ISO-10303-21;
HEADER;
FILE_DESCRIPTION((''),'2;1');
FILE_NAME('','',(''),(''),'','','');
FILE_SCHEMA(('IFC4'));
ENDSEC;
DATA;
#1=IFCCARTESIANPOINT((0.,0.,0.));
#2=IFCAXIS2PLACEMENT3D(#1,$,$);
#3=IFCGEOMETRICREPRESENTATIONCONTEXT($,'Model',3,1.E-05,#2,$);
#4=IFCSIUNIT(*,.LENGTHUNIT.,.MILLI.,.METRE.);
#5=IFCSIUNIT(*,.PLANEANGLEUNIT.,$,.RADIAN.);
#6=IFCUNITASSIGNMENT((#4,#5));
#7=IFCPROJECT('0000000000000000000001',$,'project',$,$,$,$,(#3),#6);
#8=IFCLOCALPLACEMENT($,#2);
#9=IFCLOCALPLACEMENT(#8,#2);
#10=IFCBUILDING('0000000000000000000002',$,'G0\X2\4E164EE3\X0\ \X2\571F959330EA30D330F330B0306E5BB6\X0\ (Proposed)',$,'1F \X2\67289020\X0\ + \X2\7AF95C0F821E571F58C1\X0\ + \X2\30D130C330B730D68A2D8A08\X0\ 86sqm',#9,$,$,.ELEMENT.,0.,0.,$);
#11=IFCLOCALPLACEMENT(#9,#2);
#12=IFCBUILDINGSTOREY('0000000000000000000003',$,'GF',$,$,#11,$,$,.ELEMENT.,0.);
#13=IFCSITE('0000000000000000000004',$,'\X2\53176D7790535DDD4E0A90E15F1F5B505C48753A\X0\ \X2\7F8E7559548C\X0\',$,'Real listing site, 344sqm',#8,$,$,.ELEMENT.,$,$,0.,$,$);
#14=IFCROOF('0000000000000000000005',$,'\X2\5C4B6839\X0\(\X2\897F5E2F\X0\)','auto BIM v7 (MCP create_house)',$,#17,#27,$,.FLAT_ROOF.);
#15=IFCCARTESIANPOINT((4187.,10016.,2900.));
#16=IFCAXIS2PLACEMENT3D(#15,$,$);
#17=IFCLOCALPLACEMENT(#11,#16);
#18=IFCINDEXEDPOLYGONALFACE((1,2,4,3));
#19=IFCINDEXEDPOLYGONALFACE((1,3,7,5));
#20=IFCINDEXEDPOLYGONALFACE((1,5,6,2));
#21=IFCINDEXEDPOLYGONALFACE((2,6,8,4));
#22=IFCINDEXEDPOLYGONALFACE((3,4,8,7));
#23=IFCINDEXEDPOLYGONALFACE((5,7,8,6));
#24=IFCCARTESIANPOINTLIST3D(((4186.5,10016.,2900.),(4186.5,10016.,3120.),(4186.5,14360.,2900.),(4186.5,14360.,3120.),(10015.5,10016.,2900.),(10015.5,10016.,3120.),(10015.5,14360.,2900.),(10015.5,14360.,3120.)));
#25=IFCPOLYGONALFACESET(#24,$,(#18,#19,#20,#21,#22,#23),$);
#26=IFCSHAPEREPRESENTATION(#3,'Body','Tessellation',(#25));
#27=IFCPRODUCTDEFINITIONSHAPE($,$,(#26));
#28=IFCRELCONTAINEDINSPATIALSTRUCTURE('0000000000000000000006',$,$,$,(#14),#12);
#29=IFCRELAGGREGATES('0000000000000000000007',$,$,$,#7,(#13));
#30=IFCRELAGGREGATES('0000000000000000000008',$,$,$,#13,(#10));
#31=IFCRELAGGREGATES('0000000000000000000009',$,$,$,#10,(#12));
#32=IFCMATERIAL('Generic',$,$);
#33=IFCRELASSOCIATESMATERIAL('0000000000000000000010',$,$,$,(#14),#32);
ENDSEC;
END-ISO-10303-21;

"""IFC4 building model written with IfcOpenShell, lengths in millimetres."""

from ifc_helpers import new_model, si_unit, frame, frame_2d, origin, place, context, project, spatial, rectangle, extrude, material, element, save


model = new_model("IFC4")

# Units and contexts
model_context = context("Model", 3, precision=1e-05, world=origin())
ifc_project = project(units=[si_unit("LENGTHUNIT", "METRE", prefix="MILLI"), si_unit("PLANEANGLEUNIT", "RADIAN")], contexts=[model_context])

# Site, building, storey
site_placement = place(None, origin())
site = spatial("IfcSite", under=ifc_project, at=site_placement, Name="北海道川上郡弟子屈町 美留和", ObjectType="Real listing site, 344sqm", CompositionType="ELEMENT", RefElevation=0.0)
building_placement = place(site_placement, origin())
building = spatial("IfcBuilding", under=site, at=building_placement, Name="G0世代 土間リビングの家 (Proposed)", ObjectType="1F 木造 + 竹小舞土壁 + パッシブ設計 86sqm", CompositionType="ELEMENT", ElevationOfRefHeight=0.0, ElevationOfTerrain=0.0)
storey_placement = place(building_placement, origin())
storey = spatial("IfcBuildingStorey", under=building, at=storey_placement, Name="GF", CompositionType="ELEMENT", Elevation=0.0)

# Shared definitions
ifc_material = material(Name="Generic")

# Roof
roof_1_placement = place(storey_placement, frame((4187.0, 10016.0, 2900.0)))
element("IfcRoof", 1, at=roof_1_placement, inside=storey, material=ifc_material, Name="屋根(西帯)", Description="auto BIM v7 (MCP create_house)", PredefinedType="FLAT_ROOF", context=model_context, shape_type="SweptSolid", body=[
    extrude(rectangle(XDim=5829.0, YDim=4344.0, at=frame_2d((2914.0, 2172.0))), frame((4187.0, 10016.0, 2900.0)), (0.0, 0.0, 1.0), 220.0),
])

save(model, "model.ifc")
